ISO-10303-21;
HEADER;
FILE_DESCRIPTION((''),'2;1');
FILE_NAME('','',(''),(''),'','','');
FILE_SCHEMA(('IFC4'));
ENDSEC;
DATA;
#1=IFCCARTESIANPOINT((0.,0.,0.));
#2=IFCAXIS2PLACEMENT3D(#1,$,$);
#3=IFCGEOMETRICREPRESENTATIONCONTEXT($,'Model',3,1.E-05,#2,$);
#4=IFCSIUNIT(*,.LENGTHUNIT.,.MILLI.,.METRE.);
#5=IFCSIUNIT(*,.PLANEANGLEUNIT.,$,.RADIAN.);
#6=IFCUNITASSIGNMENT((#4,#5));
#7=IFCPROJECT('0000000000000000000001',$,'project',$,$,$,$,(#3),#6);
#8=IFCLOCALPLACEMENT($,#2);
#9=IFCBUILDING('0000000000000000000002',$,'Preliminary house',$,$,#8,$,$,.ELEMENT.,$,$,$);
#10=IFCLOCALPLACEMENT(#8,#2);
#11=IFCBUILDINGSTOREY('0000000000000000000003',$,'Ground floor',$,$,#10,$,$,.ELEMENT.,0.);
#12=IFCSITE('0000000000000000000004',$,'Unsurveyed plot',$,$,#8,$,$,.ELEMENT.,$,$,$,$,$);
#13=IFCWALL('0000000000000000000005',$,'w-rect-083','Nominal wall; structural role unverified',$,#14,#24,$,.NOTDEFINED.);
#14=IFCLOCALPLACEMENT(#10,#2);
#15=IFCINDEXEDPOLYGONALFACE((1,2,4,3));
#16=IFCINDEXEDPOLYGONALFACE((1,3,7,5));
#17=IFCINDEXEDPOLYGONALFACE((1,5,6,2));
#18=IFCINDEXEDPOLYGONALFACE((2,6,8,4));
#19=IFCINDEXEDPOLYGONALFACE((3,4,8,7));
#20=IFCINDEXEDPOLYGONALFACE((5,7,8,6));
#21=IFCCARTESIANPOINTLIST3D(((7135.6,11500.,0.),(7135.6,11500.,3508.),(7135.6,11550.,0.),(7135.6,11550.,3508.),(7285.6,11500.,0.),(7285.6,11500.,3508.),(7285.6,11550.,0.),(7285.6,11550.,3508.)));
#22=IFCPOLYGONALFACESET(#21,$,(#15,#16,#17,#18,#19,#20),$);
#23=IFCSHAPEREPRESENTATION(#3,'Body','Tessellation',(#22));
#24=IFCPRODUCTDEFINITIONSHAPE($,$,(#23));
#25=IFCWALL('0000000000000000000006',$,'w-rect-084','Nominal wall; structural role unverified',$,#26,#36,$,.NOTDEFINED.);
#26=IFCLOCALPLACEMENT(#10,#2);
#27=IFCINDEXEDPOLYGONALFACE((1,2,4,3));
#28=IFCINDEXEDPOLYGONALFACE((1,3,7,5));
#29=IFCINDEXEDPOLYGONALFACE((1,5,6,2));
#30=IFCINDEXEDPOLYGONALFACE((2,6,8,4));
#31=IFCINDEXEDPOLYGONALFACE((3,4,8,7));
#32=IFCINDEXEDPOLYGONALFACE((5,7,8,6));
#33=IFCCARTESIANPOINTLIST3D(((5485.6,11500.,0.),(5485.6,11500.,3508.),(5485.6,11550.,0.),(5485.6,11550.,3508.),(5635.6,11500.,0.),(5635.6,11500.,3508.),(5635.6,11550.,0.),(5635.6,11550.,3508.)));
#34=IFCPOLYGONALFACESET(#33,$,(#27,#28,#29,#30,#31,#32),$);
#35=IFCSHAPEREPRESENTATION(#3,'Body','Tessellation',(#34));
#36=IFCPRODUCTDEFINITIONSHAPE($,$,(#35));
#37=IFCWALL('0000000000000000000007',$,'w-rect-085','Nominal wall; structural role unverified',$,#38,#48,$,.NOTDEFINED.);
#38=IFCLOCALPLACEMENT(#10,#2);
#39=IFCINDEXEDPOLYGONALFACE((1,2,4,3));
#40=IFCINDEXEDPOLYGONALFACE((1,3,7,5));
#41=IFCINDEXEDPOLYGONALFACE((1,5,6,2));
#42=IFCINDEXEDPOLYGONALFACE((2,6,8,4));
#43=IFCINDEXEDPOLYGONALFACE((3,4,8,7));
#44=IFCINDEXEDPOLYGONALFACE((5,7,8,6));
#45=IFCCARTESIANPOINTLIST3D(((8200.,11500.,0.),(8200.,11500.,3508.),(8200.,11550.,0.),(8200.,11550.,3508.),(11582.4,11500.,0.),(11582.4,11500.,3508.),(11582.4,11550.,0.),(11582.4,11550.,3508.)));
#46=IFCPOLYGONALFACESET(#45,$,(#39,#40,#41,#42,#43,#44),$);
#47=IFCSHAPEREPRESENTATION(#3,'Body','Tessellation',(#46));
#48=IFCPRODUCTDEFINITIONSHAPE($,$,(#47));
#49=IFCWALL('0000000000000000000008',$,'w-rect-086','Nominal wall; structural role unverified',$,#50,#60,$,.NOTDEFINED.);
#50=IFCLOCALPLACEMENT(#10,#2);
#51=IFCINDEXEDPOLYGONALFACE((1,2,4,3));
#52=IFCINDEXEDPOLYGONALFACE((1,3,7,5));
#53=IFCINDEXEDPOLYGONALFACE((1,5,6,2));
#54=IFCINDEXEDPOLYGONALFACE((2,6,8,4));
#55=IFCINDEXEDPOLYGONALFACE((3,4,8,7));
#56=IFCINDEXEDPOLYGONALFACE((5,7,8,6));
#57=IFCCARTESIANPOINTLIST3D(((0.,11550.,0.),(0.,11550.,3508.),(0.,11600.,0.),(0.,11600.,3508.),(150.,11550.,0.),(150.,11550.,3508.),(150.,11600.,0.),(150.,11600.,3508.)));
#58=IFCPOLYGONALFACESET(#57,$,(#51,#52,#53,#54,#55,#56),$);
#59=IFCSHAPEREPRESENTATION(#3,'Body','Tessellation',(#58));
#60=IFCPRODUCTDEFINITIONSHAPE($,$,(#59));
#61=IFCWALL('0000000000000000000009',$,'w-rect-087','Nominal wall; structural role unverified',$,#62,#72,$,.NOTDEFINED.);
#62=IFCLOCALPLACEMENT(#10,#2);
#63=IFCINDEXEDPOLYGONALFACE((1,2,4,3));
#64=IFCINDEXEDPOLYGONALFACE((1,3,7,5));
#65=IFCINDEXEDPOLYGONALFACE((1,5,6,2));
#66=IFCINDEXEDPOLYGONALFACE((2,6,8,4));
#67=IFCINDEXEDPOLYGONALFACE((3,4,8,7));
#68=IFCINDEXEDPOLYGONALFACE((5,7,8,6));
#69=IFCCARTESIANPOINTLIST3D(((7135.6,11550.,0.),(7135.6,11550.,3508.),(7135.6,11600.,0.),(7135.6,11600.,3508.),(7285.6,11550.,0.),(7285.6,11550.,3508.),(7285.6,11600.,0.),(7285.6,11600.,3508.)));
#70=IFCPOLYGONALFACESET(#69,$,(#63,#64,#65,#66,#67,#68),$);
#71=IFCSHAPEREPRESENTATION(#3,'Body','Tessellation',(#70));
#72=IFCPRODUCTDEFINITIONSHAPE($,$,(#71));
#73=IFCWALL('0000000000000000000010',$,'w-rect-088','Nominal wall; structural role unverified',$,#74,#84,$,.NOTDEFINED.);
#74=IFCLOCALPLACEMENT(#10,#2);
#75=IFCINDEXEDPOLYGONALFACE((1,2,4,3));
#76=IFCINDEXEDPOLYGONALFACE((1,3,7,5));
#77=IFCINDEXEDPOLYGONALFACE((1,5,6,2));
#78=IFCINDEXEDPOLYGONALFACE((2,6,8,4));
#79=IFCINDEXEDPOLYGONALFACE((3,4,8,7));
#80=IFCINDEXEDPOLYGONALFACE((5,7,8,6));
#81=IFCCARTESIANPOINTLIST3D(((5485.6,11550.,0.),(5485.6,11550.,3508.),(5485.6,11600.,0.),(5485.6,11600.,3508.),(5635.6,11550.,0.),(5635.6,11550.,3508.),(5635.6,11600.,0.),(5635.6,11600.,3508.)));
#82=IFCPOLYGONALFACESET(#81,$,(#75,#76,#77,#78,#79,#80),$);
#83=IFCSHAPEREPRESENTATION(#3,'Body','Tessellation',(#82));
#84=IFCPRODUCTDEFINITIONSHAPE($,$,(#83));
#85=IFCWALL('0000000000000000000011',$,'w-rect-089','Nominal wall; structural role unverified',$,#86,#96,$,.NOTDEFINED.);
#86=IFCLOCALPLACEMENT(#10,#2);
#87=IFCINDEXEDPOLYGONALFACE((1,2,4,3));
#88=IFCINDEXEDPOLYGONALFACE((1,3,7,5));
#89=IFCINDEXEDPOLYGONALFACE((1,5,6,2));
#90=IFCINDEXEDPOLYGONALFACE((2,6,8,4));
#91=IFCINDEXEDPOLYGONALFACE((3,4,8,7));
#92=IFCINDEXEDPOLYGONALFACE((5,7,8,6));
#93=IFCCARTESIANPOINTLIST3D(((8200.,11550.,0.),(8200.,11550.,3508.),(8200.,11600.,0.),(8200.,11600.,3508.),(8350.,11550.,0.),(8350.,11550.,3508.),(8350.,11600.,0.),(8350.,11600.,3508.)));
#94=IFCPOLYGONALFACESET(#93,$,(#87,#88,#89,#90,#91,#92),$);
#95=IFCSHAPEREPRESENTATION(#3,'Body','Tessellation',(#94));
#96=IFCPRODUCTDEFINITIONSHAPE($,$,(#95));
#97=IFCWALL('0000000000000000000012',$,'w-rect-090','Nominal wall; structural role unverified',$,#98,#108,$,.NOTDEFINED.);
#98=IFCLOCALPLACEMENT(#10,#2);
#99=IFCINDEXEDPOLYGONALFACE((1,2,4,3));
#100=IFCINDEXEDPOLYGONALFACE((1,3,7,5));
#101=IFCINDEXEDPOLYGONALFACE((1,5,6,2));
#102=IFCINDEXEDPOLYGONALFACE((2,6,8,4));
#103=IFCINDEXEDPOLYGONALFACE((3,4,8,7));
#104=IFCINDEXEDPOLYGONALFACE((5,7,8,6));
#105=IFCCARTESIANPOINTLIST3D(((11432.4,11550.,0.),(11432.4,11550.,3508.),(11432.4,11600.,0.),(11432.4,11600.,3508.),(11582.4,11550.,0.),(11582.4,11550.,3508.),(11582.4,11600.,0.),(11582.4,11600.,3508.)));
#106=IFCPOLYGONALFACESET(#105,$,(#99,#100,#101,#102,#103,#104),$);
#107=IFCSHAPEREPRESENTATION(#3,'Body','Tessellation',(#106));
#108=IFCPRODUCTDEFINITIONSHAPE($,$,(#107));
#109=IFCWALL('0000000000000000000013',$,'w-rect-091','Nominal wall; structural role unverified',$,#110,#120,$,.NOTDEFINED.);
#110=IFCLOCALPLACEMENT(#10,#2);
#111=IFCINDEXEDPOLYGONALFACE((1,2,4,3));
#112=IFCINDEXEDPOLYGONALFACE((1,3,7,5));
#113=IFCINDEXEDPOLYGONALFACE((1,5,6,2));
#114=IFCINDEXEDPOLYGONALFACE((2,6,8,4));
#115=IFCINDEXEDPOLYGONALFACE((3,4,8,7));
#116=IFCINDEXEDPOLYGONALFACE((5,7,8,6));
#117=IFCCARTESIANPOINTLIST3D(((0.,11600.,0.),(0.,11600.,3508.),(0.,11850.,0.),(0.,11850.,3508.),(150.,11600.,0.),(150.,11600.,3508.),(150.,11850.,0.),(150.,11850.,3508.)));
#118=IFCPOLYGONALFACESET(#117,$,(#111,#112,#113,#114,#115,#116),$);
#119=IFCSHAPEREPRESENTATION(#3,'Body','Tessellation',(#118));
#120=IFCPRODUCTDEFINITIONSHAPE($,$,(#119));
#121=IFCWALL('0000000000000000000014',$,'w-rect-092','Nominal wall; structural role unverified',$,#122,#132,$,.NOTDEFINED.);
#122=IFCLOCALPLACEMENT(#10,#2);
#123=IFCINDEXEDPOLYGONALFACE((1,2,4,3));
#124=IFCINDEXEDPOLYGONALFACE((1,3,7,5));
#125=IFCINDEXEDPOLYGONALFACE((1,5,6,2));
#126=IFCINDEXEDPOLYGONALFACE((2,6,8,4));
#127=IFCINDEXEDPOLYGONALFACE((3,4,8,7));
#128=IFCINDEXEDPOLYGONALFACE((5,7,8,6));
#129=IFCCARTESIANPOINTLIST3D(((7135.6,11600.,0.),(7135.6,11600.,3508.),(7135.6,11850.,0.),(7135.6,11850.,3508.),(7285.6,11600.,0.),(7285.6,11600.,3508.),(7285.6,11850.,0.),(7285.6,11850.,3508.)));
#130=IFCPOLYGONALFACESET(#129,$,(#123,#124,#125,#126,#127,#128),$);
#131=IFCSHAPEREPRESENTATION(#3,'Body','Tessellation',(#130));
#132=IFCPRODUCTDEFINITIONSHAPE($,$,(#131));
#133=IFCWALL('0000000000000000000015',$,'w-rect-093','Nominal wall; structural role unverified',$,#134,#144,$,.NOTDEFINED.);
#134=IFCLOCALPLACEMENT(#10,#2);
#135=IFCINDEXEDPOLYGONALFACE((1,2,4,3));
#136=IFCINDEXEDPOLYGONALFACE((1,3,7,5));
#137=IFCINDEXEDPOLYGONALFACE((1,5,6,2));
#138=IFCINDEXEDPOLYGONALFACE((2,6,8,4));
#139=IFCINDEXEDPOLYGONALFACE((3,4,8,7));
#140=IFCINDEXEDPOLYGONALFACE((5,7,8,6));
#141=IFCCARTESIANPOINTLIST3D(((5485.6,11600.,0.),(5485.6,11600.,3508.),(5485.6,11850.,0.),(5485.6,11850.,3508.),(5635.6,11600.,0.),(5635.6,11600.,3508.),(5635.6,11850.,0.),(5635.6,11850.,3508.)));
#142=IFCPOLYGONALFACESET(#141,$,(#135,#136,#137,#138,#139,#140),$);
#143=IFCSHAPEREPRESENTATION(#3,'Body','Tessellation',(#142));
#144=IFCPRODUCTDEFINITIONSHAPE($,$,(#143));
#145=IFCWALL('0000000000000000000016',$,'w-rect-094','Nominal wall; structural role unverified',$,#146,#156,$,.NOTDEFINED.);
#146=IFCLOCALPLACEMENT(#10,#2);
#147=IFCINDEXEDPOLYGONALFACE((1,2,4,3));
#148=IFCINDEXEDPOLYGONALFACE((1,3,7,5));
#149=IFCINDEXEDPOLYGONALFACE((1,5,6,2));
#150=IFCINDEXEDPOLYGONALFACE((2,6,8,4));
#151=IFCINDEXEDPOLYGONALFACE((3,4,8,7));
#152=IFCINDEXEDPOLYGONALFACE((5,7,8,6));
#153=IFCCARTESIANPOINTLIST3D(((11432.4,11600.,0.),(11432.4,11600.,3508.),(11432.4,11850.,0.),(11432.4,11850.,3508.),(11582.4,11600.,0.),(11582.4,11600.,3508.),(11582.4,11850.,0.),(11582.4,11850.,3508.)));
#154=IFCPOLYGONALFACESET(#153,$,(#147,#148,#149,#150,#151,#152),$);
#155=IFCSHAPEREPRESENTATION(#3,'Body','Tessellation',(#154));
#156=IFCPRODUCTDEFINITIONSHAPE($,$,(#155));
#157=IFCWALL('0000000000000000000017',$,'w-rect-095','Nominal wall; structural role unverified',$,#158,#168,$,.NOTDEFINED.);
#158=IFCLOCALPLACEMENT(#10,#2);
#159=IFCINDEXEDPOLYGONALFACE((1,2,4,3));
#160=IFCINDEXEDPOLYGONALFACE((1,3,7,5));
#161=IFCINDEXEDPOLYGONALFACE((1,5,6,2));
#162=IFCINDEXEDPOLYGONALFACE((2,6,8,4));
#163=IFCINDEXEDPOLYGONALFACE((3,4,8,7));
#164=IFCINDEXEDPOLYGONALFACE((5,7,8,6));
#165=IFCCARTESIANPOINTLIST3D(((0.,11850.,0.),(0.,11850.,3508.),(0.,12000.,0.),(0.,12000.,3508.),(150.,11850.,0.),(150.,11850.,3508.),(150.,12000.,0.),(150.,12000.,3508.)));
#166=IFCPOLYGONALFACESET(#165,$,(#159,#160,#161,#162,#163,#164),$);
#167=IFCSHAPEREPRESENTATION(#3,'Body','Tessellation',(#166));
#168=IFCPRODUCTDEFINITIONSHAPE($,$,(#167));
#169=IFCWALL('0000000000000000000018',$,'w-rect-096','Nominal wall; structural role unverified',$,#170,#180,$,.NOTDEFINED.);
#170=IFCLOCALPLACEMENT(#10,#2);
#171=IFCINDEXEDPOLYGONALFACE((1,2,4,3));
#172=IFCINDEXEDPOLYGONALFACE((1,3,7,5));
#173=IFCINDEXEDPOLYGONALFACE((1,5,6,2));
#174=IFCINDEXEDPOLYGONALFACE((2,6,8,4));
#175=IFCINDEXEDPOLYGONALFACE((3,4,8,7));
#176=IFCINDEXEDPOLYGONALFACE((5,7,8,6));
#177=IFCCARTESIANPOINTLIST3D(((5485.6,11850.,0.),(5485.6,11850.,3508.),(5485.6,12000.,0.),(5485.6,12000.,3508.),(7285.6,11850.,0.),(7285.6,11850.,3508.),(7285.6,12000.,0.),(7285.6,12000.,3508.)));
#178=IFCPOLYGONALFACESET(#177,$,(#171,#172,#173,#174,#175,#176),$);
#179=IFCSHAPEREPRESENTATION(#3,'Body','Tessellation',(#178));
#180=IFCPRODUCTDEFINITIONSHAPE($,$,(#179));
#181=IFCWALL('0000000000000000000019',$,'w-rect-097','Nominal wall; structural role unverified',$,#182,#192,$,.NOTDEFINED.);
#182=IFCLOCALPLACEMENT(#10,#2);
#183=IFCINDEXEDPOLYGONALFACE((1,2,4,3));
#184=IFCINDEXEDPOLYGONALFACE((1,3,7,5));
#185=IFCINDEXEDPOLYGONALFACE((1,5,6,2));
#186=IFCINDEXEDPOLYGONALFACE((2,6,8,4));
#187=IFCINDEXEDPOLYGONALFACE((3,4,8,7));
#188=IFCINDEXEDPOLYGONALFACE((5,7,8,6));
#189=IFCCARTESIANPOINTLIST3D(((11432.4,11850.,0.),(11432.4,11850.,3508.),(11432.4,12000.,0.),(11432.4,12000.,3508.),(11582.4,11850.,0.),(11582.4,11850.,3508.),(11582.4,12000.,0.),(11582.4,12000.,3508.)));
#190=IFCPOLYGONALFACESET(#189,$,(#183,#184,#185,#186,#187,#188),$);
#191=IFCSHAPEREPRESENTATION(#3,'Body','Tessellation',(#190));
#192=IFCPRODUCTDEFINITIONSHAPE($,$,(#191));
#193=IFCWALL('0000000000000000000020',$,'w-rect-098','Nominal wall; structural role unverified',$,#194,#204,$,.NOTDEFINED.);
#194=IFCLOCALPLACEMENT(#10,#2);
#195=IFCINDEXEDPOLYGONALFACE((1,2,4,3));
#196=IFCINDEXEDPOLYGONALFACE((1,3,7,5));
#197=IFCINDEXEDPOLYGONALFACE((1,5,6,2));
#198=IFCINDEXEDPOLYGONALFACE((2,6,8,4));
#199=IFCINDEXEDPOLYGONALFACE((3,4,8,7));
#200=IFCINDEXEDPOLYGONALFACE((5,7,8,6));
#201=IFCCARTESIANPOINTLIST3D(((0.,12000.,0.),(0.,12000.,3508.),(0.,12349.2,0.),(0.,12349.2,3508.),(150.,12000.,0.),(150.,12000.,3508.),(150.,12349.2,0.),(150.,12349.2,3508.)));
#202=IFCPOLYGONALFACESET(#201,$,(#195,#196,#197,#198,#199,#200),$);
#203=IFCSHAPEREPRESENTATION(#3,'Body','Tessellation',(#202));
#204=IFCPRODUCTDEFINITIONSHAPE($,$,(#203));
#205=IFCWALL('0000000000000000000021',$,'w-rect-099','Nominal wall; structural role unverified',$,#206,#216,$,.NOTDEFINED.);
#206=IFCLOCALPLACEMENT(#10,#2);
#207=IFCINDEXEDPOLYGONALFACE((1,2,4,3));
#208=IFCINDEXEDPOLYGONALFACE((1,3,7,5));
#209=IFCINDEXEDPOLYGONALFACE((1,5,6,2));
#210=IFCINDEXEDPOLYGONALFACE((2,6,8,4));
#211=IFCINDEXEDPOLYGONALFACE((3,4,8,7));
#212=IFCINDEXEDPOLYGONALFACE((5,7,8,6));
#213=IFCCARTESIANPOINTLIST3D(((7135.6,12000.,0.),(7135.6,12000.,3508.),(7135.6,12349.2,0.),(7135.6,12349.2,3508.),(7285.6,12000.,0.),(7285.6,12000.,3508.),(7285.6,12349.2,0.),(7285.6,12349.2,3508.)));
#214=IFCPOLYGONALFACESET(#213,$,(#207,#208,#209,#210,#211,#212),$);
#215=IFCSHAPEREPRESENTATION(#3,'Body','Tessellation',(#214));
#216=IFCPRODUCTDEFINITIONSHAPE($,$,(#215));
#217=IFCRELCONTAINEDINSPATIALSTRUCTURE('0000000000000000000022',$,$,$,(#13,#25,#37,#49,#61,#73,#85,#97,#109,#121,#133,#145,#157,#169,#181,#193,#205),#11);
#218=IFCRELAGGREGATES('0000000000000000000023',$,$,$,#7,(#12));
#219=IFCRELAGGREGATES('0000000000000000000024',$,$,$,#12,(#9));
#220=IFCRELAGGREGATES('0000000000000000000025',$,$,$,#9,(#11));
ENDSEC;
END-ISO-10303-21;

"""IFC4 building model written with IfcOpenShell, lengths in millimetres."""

from ifc_helpers import new_model, si_unit, origin, place, context, project, spatial, polyline, outline, extrude, element, save


model = new_model("IFC4")

# Units and contexts
model_context = context("Model", 3, precision=1e-05, world=origin())
ifc_project = project(units=[si_unit("LENGTHUNIT", "METRE", prefix="MILLI"), si_unit("PLANEANGLEUNIT", "RADIAN")], contexts=[model_context])

# Site, building, storey
placement_1 = place(None, origin())
site = spatial("IfcSite", under=ifc_project, at=placement_1, Name="Unsurveyed plot", CompositionType="ELEMENT")
building = spatial("IfcBuilding", under=site, at=placement_1, Name="Preliminary house", CompositionType="ELEMENT")
placement_2 = place(placement_1, origin())
storey = spatial("IfcBuildingStorey", under=building, at=placement_2, Name="Ground floor", CompositionType="ELEMENT", Elevation=0.0)

# Walls
element("IfcWall", 1, at=placement_2, inside=storey, Name="w-rect-083", Description="Nominal wall; structural role unverified", PredefinedType="NOTDEFINED", context=model_context, shape_type="SweptSolid", body=[
    extrude(outline(polyline([(7135.6, 11500.0), (7285.6, 11500.0), (7285.6, 11550.0), (7135.6, 11550.0), (7135.6, 11500.0)])), origin(), (0.0, 0.0, 1.0), 3508.0),
])
element("IfcWall", 2, at=placement_2, inside=storey, Name="w-rect-084", Description="Nominal wall; structural role unverified", PredefinedType="NOTDEFINED", context=model_context, shape_type="SweptSolid", body=[
    extrude(outline(polyline([(5485.6, 11500.0), (5635.6, 11500.0), (5635.6, 11550.0), (5485.6, 11550.0), (5485.6, 11500.0)])), origin(), (0.0, 0.0, 1.0), 3508.0),
])
element("IfcWall", 3, at=placement_2, inside=storey, Name="w-rect-085", Description="Nominal wall; structural role unverified", PredefinedType="NOTDEFINED", context=model_context, shape_type="SweptSolid", body=[
    extrude(outline(polyline([(8200.0, 11500.0), (11582.4, 11500.0), (11582.4, 11550.0), (8200.0, 11550.0), (8200.0, 11500.0)])), origin(), (0.0, 0.0, 1.0), 3508.0),
])
element("IfcWall", 4, at=placement_2, inside=storey, Name="w-rect-086", Description="Nominal wall; structural role unverified", PredefinedType="NOTDEFINED", context=model_context, shape_type="SweptSolid", body=[
    extrude(outline(polyline([(0.0, 11550.0), (150.0, 11550.0), (150.0, 11600.0), (0.0, 11600.0), (0.0, 11550.0)])), origin(), (0.0, 0.0, 1.0), 3508.0),
])
element("IfcWall", 5, at=placement_2, inside=storey, Name="w-rect-087", Description="Nominal wall; structural role unverified", PredefinedType="NOTDEFINED", context=model_context, shape_type="SweptSolid", body=[
    extrude(outline(polyline([(7135.6, 11550.0), (7285.6, 11550.0), (7285.6, 11600.0), (7135.6, 11600.0), (7135.6, 11550.0)])), origin(), (0.0, 0.0, 1.0), 3508.0),
])
element("IfcWall", 6, at=placement_2, inside=storey, Name="w-rect-088", Description="Nominal wall; structural role unverified", PredefinedType="NOTDEFINED", context=model_context, shape_type="SweptSolid", body=[
    extrude(outline(polyline([(5485.6, 11550.0), (5635.6, 11550.0), (5635.6, 11600.0), (5485.6, 11600.0), (5485.6, 11550.0)])), origin(), (0.0, 0.0, 1.0), 3508.0),
])
element("IfcWall", 7, at=placement_2, inside=storey, Name="w-rect-089", Description="Nominal wall; structural role unverified", PredefinedType="NOTDEFINED", context=model_context, shape_type="SweptSolid", body=[
    extrude(outline(polyline([(8200.0, 11550.0), (8350.0, 11550.0), (8350.0, 11600.0), (8200.0, 11600.0), (8200.0, 11550.0)])), origin(), (0.0, 0.0, 1.0), 3508.0),
])
element("IfcWall", 8, at=placement_2, inside=storey, Name="w-rect-090", Description="Nominal wall; structural role unverified", PredefinedType="NOTDEFINED", context=model_context, shape_type="SweptSolid", body=[
    extrude(outline(polyline([(11432.4, 11550.0), (11582.4, 11550.0), (11582.4, 11600.0), (11432.4, 11600.0), (11432.4, 11550.0)])), origin(), (0.0, 0.0, 1.0), 3508.0),
])
element("IfcWall", 9, at=placement_2, inside=storey, Name="w-rect-091", Description="Nominal wall; structural role unverified", PredefinedType="NOTDEFINED", context=model_context, shape_type="SweptSolid", body=[
    extrude(outline(polyline([(0.0, 11600.0), (150.0, 11600.0), (150.0, 11850.0), (0.0, 11850.0), (0.0, 11600.0)])), origin(), (0.0, 0.0, 1.0), 3508.0),
])
element("IfcWall", 10, at=placement_2, inside=storey, Name="w-rect-092", Description="Nominal wall; structural role unverified", PredefinedType="NOTDEFINED", context=model_context, shape_type="SweptSolid", body=[
    extrude(outline(polyline([(7135.6, 11600.0), (7285.6, 11600.0), (7285.6, 11850.0), (7135.6, 11850.0), (7135.6, 11600.0)])), origin(), (0.0, 0.0, 1.0), 3508.0),
])
element("IfcWall", 11, at=placement_2, inside=storey, Name="w-rect-093", Description="Nominal wall; structural role unverified", PredefinedType="NOTDEFINED", context=model_context, shape_type="SweptSolid", body=[
    extrude(outline(polyline([(5485.6, 11600.0), (5635.6, 11600.0), (5635.6, 11850.0), (5485.6, 11850.0), (5485.6, 11600.0)])), origin(), (0.0, 0.0, 1.0), 3508.0),
])
element("IfcWall", 12, at=placement_2, inside=storey, Name="w-rect-094", Description="Nominal wall; structural role unverified", PredefinedType="NOTDEFINED", context=model_context, shape_type="SweptSolid", body=[
    extrude(outline(polyline([(11432.4, 11600.0), (11582.4, 11600.0), (11582.4, 11850.0), (11432.4, 11850.0), (11432.4, 11600.0)])), origin(), (0.0, 0.0, 1.0), 3508.0),
])
element("IfcWall", 13, at=placement_2, inside=storey, Name="w-rect-095", Description="Nominal wall; structural role unverified", PredefinedType="NOTDEFINED", context=model_context, shape_type="SweptSolid", body=[
    extrude(outline(polyline([(0.0, 11850.0), (150.0, 11850.0), (150.0, 12000.0), (0.0, 12000.0), (0.0, 11850.0)])), origin(), (0.0, 0.0, 1.0), 3508.0),
])
element("IfcWall", 14, at=placement_2, inside=storey, Name="w-rect-096", Description="Nominal wall; structural role unverified", PredefinedType="NOTDEFINED", context=model_context, shape_type="SweptSolid", body=[
    extrude(outline(polyline([(5485.6, 11850.0), (7285.6, 11850.0), (7285.6, 12000.0), (5485.6, 12000.0), (5485.6, 11850.0)])), origin(), (0.0, 0.0, 1.0), 3508.0),
])
element("IfcWall", 15, at=placement_2, inside=storey, Name="w-rect-097", Description="Nominal wall; structural role unverified", PredefinedType="NOTDEFINED", context=model_context, shape_type="SweptSolid", body=[
    extrude(outline(polyline([(11432.4, 11850.0), (11582.4, 11850.0), (11582.4, 12000.0), (11432.4, 12000.0), (11432.4, 11850.0)])), origin(), (0.0, 0.0, 1.0), 3508.0),
])
element("IfcWall", 16, at=placement_2, inside=storey, Name="w-rect-098", Description="Nominal wall; structural role unverified", PredefinedType="NOTDEFINED", context=model_context, shape_type="SweptSolid", body=[
    extrude(outline(polyline([(0.0, 12000.0), (150.0, 12000.0), (150.0, 12349.2), (0.0, 12349.2), (0.0, 12000.0)])), origin(), (0.0, 0.0, 1.0), 3508.0),
])
element("IfcWall", 17, at=placement_2, inside=storey, Name="w-rect-099", Description="Nominal wall; structural role unverified", PredefinedType="NOTDEFINED", context=model_context, shape_type="SweptSolid", body=[
    extrude(outline(polyline([(7135.6, 12000.0), (7285.6, 12000.0), (7285.6, 12349.2), (7135.6, 12349.2), (7135.6, 12000.0)])), origin(), (0.0, 0.0, 1.0), 3508.0),
])

save(model, "model.ifc")
